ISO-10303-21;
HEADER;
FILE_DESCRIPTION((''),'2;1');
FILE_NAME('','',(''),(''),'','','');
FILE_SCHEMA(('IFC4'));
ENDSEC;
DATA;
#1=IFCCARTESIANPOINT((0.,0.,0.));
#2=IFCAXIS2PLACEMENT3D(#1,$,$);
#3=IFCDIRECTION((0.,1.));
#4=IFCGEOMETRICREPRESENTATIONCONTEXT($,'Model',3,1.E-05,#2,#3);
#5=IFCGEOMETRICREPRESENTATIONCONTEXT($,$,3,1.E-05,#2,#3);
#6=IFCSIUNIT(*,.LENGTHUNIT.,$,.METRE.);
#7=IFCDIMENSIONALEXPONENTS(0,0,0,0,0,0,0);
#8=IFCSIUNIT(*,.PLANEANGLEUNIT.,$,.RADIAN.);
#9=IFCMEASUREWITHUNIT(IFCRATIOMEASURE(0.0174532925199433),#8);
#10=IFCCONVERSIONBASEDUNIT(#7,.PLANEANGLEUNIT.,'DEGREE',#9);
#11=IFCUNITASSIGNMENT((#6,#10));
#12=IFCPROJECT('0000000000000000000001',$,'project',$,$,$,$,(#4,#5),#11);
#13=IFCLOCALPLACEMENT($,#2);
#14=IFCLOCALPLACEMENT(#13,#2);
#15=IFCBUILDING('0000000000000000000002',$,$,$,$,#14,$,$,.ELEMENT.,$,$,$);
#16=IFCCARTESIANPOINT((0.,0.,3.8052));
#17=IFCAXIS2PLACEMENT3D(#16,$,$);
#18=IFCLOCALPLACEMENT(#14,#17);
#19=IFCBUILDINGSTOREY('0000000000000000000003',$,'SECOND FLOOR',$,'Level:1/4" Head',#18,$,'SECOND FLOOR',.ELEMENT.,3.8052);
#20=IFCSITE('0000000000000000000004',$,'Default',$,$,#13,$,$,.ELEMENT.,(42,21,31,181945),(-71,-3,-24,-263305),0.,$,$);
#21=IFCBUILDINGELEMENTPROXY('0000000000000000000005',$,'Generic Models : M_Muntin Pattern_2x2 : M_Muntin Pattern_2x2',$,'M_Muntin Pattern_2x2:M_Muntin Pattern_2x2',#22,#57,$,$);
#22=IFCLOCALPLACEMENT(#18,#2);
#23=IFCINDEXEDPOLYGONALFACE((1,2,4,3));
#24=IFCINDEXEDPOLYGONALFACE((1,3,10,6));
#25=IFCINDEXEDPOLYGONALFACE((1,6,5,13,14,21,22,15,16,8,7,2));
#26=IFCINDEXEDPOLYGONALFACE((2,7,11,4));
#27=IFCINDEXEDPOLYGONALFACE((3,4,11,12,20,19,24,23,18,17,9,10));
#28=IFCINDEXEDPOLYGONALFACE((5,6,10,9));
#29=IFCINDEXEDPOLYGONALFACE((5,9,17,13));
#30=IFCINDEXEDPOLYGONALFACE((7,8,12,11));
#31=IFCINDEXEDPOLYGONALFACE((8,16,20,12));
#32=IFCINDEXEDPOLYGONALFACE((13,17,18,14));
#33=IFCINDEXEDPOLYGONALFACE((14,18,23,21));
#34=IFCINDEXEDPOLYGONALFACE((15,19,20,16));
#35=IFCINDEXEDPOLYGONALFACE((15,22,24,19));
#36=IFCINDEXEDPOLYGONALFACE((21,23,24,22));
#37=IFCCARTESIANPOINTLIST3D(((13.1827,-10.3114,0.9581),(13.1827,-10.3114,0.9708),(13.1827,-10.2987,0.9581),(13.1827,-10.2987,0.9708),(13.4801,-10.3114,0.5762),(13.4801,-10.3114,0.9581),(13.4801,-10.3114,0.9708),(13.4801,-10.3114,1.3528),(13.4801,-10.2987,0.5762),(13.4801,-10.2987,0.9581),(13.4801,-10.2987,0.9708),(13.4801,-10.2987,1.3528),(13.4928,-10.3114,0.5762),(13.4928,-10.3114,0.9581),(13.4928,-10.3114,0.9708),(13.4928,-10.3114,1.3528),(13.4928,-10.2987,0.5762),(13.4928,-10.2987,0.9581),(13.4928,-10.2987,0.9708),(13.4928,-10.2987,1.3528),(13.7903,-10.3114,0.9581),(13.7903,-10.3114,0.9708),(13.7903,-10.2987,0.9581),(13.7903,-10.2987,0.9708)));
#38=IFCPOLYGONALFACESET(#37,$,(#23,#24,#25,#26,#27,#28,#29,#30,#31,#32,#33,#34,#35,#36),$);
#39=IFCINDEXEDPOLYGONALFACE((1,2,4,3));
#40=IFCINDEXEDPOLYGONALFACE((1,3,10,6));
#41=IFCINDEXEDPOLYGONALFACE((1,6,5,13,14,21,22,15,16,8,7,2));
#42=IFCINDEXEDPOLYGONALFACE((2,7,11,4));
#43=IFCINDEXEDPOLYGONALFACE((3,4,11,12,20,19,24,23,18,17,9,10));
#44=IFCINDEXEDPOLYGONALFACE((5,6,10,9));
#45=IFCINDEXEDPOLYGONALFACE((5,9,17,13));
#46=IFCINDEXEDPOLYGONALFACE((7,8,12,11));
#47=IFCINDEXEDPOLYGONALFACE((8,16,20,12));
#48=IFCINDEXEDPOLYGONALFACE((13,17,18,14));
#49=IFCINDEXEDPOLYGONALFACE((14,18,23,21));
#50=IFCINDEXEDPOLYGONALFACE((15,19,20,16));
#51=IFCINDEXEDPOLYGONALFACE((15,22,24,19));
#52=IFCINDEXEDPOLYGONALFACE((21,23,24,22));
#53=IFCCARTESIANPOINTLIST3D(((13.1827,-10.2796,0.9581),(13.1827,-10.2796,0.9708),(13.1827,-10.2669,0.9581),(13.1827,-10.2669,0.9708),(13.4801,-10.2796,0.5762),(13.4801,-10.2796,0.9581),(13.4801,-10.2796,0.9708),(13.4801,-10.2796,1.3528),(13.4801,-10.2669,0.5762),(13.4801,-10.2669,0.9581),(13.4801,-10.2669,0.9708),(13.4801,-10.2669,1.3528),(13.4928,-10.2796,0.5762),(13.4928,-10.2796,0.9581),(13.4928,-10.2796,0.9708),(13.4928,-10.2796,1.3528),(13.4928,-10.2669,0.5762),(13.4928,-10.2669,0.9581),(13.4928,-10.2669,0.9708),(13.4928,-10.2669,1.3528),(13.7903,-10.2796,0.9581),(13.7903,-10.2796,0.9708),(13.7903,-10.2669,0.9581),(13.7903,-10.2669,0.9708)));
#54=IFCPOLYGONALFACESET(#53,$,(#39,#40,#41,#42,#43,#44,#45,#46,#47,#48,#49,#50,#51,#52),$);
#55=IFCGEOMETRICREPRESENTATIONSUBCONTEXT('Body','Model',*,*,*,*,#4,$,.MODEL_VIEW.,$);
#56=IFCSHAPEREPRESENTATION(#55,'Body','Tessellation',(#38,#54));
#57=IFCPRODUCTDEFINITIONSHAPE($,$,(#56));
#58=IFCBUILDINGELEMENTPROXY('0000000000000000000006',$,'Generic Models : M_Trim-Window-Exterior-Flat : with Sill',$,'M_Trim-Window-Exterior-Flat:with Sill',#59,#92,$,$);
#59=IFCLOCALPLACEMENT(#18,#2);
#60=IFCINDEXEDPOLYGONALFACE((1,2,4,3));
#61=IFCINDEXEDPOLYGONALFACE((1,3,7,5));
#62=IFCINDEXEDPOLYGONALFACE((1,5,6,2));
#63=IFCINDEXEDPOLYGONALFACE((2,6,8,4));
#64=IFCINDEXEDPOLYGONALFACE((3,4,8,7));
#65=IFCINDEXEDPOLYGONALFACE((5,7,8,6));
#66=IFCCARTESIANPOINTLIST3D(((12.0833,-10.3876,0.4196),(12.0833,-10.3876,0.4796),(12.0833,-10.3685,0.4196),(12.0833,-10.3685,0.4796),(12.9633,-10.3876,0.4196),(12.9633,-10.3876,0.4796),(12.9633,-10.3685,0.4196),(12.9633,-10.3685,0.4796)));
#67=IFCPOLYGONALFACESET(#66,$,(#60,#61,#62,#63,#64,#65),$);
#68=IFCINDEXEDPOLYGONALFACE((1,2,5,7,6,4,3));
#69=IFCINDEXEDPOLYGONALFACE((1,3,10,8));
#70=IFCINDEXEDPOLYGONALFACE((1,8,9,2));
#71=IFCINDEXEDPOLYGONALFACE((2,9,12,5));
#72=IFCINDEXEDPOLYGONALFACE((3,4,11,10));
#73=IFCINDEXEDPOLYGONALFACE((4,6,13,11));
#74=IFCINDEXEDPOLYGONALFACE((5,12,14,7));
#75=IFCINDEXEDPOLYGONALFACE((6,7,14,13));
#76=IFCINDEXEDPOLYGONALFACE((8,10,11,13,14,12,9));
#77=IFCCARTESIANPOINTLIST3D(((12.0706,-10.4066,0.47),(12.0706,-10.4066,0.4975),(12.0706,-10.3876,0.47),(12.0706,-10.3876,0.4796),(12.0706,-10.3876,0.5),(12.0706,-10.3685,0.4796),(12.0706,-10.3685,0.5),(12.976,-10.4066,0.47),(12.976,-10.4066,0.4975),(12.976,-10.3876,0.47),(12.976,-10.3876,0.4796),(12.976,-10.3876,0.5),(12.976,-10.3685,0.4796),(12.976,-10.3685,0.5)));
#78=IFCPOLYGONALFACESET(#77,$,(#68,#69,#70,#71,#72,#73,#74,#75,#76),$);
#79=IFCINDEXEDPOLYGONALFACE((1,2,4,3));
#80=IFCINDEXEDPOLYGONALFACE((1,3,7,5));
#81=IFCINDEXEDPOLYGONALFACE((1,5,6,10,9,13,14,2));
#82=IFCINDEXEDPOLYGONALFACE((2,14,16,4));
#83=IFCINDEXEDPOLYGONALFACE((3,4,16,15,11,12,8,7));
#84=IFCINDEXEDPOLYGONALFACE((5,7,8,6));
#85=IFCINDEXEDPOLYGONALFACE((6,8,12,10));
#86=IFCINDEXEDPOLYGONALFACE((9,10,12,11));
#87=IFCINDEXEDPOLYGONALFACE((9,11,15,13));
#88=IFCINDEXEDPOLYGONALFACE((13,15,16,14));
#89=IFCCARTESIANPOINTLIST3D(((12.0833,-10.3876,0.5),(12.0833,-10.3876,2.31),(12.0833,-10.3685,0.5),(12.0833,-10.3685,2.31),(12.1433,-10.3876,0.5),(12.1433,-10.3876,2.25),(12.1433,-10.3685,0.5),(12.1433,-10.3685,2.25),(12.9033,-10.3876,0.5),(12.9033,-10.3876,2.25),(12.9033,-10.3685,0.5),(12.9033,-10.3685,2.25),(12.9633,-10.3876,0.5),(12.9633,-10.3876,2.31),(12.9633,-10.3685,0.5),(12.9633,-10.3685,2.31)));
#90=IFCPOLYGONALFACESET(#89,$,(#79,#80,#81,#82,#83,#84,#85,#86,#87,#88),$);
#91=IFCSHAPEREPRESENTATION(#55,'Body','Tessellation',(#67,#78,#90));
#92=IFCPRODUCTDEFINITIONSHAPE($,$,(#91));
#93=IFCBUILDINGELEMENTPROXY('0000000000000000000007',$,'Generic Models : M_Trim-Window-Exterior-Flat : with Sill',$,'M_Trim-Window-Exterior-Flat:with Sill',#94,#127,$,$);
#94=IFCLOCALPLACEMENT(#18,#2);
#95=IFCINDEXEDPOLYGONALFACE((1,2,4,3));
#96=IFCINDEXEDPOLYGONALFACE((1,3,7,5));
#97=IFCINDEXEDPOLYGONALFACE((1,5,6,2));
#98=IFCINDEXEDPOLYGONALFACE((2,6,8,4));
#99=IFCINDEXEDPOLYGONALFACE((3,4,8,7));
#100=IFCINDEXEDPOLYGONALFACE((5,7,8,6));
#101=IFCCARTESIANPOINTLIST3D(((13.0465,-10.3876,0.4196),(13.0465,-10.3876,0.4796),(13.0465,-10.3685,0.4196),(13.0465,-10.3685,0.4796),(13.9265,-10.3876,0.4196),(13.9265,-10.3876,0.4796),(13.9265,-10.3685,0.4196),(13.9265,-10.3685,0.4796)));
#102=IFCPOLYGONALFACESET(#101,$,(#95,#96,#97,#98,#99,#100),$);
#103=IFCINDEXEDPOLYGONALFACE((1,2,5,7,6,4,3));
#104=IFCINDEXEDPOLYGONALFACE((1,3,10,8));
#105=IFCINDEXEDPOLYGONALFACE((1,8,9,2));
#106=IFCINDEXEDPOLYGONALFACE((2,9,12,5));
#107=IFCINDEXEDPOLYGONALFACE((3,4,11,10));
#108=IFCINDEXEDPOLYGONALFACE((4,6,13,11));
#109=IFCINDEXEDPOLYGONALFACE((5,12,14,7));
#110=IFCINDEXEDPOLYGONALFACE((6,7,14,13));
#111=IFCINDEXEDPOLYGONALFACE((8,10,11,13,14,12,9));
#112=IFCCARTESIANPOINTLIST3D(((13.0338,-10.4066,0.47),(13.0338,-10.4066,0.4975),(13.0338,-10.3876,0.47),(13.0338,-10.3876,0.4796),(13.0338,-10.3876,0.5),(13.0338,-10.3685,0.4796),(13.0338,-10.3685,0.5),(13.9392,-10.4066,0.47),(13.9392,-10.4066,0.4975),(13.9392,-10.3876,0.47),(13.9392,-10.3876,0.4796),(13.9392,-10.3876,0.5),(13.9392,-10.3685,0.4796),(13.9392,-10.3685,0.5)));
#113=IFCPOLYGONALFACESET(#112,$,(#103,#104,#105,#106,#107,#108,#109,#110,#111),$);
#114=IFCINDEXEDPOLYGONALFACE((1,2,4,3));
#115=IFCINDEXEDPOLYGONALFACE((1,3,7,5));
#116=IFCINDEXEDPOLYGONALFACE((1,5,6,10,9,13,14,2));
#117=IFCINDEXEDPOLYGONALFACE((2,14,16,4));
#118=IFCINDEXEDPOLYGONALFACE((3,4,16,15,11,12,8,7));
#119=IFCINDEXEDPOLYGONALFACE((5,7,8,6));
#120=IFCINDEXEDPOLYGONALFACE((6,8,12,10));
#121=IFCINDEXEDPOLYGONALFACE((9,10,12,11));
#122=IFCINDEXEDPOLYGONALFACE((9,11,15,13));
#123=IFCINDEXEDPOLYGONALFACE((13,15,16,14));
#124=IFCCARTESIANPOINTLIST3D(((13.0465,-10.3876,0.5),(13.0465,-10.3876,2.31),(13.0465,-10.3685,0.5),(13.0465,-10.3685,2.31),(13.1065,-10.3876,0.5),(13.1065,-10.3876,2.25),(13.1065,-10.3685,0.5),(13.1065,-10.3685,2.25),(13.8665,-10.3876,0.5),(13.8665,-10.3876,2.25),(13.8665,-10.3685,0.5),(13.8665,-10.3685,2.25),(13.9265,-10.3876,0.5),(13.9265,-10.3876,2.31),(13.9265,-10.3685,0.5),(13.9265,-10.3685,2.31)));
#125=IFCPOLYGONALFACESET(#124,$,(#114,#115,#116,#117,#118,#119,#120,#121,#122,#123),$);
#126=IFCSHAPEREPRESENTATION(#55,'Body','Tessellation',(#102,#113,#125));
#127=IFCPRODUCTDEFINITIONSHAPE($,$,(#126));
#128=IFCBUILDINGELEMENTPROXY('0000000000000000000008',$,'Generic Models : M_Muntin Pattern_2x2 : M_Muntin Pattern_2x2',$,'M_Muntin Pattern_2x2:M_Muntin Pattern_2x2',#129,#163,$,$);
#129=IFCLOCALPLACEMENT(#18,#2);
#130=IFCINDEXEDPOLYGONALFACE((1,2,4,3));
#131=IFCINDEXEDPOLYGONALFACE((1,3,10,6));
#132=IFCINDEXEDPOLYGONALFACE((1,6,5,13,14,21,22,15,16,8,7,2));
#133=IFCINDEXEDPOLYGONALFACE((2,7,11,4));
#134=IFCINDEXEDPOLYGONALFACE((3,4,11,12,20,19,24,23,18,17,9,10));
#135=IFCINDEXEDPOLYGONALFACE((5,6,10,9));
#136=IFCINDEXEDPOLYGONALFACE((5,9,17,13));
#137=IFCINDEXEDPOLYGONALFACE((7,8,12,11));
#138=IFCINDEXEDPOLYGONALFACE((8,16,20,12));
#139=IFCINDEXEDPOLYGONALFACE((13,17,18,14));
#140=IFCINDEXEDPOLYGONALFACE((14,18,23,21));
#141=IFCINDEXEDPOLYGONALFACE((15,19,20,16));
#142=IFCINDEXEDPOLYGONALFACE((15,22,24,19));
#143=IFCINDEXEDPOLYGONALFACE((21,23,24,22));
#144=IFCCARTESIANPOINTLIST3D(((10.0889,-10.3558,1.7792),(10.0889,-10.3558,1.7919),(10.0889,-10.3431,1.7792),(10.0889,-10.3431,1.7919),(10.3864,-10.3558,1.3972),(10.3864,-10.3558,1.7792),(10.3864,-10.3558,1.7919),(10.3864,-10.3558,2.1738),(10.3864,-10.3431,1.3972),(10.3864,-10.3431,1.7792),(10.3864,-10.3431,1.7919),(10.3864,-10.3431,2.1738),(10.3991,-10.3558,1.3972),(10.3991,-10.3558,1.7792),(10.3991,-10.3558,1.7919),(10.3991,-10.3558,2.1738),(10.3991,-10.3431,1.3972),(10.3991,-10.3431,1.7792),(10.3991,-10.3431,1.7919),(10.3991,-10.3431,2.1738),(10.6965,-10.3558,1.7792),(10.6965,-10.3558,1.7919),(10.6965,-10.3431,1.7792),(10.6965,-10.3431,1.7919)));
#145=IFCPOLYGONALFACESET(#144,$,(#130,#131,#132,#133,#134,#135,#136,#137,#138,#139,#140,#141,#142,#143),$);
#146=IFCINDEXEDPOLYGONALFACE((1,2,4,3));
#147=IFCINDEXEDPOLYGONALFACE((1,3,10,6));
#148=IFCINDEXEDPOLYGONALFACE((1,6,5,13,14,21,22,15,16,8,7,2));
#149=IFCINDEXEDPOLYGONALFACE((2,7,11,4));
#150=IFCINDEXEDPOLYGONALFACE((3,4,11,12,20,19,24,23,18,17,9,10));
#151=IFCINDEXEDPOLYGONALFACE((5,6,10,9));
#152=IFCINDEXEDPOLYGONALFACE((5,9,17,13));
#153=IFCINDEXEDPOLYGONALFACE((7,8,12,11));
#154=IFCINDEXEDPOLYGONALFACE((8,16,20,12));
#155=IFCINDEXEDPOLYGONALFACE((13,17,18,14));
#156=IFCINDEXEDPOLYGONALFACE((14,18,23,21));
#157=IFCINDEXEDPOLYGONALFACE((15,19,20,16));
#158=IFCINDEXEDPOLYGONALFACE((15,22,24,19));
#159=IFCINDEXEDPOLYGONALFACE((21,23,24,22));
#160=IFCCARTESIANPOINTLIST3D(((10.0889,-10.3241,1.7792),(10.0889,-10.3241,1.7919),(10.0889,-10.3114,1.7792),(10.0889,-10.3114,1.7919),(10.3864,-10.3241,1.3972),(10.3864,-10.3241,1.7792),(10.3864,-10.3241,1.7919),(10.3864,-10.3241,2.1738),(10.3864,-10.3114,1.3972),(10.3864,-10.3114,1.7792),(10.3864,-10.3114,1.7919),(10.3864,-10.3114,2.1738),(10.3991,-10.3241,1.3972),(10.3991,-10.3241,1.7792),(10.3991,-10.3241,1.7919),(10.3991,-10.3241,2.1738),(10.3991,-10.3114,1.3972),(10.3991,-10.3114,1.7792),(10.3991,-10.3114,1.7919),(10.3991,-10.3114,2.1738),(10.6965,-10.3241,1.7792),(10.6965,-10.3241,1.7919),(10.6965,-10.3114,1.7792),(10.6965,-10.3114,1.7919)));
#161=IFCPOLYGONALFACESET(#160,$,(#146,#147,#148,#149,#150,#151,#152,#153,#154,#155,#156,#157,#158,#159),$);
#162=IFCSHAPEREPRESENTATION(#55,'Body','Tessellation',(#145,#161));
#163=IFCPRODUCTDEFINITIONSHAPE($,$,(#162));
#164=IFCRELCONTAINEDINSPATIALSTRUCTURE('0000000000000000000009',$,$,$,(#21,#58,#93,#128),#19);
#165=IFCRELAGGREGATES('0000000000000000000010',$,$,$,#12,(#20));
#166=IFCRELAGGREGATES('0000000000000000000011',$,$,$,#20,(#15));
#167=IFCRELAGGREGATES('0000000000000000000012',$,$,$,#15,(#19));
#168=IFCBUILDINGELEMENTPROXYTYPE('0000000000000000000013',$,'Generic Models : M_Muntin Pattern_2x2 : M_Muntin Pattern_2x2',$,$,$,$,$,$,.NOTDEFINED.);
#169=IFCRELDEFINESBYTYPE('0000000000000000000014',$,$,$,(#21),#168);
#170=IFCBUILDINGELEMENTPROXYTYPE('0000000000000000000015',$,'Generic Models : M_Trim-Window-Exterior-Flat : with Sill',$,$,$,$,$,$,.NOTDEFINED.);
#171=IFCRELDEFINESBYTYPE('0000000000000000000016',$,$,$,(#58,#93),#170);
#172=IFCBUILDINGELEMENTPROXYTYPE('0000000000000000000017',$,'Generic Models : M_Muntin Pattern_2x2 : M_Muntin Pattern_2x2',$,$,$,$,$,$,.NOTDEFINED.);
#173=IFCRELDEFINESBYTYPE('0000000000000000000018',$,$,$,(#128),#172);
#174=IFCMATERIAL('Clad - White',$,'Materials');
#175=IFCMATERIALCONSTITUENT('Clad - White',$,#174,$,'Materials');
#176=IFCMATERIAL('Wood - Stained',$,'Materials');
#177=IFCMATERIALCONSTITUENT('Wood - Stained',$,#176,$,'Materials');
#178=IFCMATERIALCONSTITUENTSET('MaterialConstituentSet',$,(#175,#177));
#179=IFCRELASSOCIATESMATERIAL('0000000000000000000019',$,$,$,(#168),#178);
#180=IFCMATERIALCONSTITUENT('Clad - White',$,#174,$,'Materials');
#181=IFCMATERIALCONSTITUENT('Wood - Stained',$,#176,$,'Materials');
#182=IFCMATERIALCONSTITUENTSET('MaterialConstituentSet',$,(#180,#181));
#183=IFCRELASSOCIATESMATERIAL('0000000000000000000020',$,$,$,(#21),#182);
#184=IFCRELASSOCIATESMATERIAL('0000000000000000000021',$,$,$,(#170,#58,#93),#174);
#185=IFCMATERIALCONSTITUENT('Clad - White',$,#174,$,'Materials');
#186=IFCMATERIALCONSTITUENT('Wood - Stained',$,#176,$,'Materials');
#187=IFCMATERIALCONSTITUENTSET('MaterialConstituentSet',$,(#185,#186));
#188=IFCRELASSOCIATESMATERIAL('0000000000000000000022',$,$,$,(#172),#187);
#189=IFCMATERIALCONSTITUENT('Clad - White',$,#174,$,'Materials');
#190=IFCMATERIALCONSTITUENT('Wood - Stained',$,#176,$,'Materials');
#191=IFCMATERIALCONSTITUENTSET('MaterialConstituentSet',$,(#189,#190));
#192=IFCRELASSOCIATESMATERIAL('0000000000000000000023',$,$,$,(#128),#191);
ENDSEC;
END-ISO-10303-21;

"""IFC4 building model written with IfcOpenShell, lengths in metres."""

from ifc_helpers import new_model, entity, si_unit, converted_unit, direction, frame, origin, origin_2d_with_axis, place, context, subcontext, project, spatial, polyline, rectangle, outline, extrude, source, transform, mapped, material, constituent, constituent_set, type_object, type_shapes, element, save


model = new_model("IFC4")

# Units and contexts
model_context = context("Model", 3, precision=1e-05, world=origin(), true_north=direction((0.0, 1.0)))
context_of_model = context(None, 3, precision=1e-05, world=origin(), true_north=direction((0.0, 1.0)))
body_context = subcontext(model_context, "Body", "Model", "MODEL_VIEW")
ifc_project = project(units=[si_unit("LENGTHUNIT", "METRE"), converted_unit("PLANEANGLEUNIT", "DEGREE", entity("IfcRatioMeasure", 0.0174532925199433), si_unit("PLANEANGLEUNIT", "RADIAN"), dimensions=[0, 0, 0, 0, 0, 0, 0])], contexts=[model_context, context_of_model])

# Site, building, storey
site_placement = place(None, origin())
site = spatial("IfcSite", under=ifc_project, at=site_placement, Name="Default", CompositionType="ELEMENT", RefLatitude=(42, 21, 31, 181945), RefLongitude=(-71, -3, -24, -263305), RefElevation=0.0)
building_placement = place(site_placement, origin())
building = spatial("IfcBuilding", under=site, at=building_placement, CompositionType="ELEMENT")
storey_placement = place(building_placement, frame((0.0, 0.0, 3.8052)))
storey = spatial("IfcBuildingStorey", under=building, at=storey_placement, Name="SECOND FLOOR", ObjectType="Level:1/4\" Head", LongName="SECOND FLOOR", CompositionType="ELEMENT", Elevation=3.8052)

# Shared definitions
ifc_material_1 = material(Name="Wood - Stained", Category="Materials")

# Building element proxies
ifc_material_2 = material(Name="Clad - White", Category="Materials")
ifc_constituent_1 = constituent(ifc_material_2, Name="Clad - White", Category="Materials")
ifc_constituent_2 = constituent(ifc_material_1, Name="Wood - Stained", Category="Materials")
ifc_constituent_set_1 = constituent_set(constituents=[ifc_constituent_1, ifc_constituent_2], Name="MaterialConstituentSet")
building_element_proxy_type_1 = type_object("IfcBuildingElementProxyType", Name="Generic Models : M_Muntin Pattern_2x2 : M_Muntin Pattern_2x2", PredefinedType="NOTDEFINED", material=ifc_constituent_set_1)
shared_shape_1 = source(origin(), body_context, "Body", "SweptSolid", [
    extrude(outline(polyline([(0.0064, -0.0064), (0.3883, -0.0064), (0.3883, 0.0063), (0.0064, 0.0063), (0.0064, 0.3038), (-0.0063, 0.3038), (-0.0063, 0.0063), (-0.3883, 0.0063), (-0.3883, -0.0064), (-0.0063, -0.0064), (-0.0063, -0.3038), (0.0064, -0.3038), (0.0064, -0.0064)])), frame((0.0, 0.0095, 0.3883), z_axis=(0.0, 1.0, 0.0), x_axis=(0.0, 0.0, 1.0)), (0.0, 0.0, 1.0), 0.0127),
    extrude(outline(polyline([(0.0064, -0.0064), (0.3883, -0.0064), (0.3883, 0.0063), (0.0064, 0.0063), (0.0064, 0.3038), (-0.0063, 0.3038), (-0.0063, 0.0063), (-0.3883, 0.0063), (-0.3883, -0.0064), (-0.0063, -0.0064), (-0.0063, -0.3038), (0.0064, -0.3038), (0.0064, -0.0064)])), frame((0.0, -0.0222, 0.3883), z_axis=(0.0, 1.0, 0.0), x_axis=(0.0, 0.0, 1.0)), (0.0, 0.0, 1.0), 0.0127),
])
type_shapes(building_element_proxy_type_1, [shared_shape_1])
ifc_constituent_3 = constituent(ifc_material_2, Name="Clad - White", Category="Materials")
ifc_constituent_4 = constituent(ifc_material_1, Name="Wood - Stained", Category="Materials")
ifc_constituent_set_2 = constituent_set(constituents=[ifc_constituent_3, ifc_constituent_4], Name="MaterialConstituentSet")
proxy_1_placement = place(storey_placement, frame((13.4865, -10.2891, 0.5762), z_axis=(0.0, 0.0, 1.0), x_axis=(-1.0, 0.0, 0.0)))
element("IfcBuildingElementProxy", 1, at=proxy_1_placement, inside=storey, type_object=building_element_proxy_type_1, material=ifc_constituent_set_2, Name="Generic Models : M_Muntin Pattern_2x2 : M_Muntin Pattern_2x2", ObjectType="M_Muntin Pattern_2x2:M_Muntin Pattern_2x2", context=body_context, shape_type="MappedRepresentation", body=[
    mapped(shared_shape_1, transform((0.0, 0.0, 0.0), scale=1.0)),
])
building_element_proxy_type_2 = type_object("IfcBuildingElementProxyType", Name="Generic Models : M_Trim-Window-Exterior-Flat : with Sill", PredefinedType="NOTDEFINED", material=ifc_material_2)
shared_shape_2 = source(origin(), body_context, "Body", "SweptSolid", [
    extrude(rectangle(XDim=0.88, YDim=0.06, at=origin_2d_with_axis()), frame((0.0, -1.8004, 0.0), z_axis=(0.0, 0.0, 1.0), x_axis=(-1.0, 0.0, 0.0)), (0.0, 0.0, 1.0), 0.0191),
    extrude(outline(polyline([(-0.019, -0.0152), (0.0, -0.0152), (0.0, -0.0057), (0.019, -0.0057), (0.019, 0.0148), (0.0, 0.0148), (-0.019, 0.0123), (-0.019, -0.0152)])), frame((-0.4527, -1.7648, 0.019), z_axis=(1.0, 0.0, 0.0), x_axis=(0.0, 0.0, -1.0)), (0.0, 0.0, 1.0), 0.9054),
    extrude(outline(polyline([(-0.92, -0.44), (0.89, -0.44), (0.89, -0.38), (-0.86, -0.38), (-0.86, 0.38), (0.89, 0.38), (0.89, 0.44), (-0.92, 0.44), (-0.92, -0.44)])), frame((0.0, -0.86, 0.0), z_axis=(0.0, 0.0, 1.0), x_axis=(0.0, -1.0, 0.0)), (0.0, 0.0, 1.0), 0.0191),
])
type_shapes(building_element_proxy_type_2, [shared_shape_2])
for number, where, z_axis, x_axis, name in (
    (2, (12.5233, -10.3685, 2.25), (0.0, -1.0, 0.0), (1.0, 0.0, 0.0), "Generic Models : M_Trim-Window-Exterior-Flat : with Sill"),
    (3, (13.4865, -10.3685, 2.25), (0.0, -1.0, 0.0), (1.0, 0.0, 0.0), "Generic Models : M_Trim-Window-Exterior-Flat : with Sill"),
):
    element("IfcBuildingElementProxy", number, at=place(storey_placement, frame(where, z_axis=z_axis, x_axis=x_axis)), inside=storey, type_object=building_element_proxy_type_2, material=ifc_material_2, Name=name, ObjectType="M_Trim-Window-Exterior-Flat:with Sill", context=body_context, shape_type="MappedRepresentation", body=[
        mapped(shared_shape_2, transform((0.0, 0.0, 0.0), scale=1.0)),
    ])
ifc_constituent_5 = constituent(ifc_material_2, Name="Clad - White", Category="Materials")
ifc_constituent_6 = constituent(ifc_material_1, Name="Wood - Stained", Category="Materials")
ifc_constituent_set_3 = constituent_set(constituents=[ifc_constituent_5, ifc_constituent_6], Name="MaterialConstituentSet")
ifc_constituent_7 = constituent(ifc_material_2, Name="Clad - White", Category="Materials")
ifc_constituent_8 = constituent(ifc_material_1, Name="Wood - Stained", Category="Materials")
ifc_constituent_set_4 = constituent_set(constituents=[ifc_constituent_7, ifc_constituent_8], Name="MaterialConstituentSet")
building_element_proxy_type_3 = type_object("IfcBuildingElementProxyType", Name="Generic Models : M_Muntin Pattern_2x2 : M_Muntin Pattern_2x2", PredefinedType="NOTDEFINED", material=ifc_constituent_set_4)
shared_shape_3 = source(origin(), body_context, "Body", "SweptSolid", [
    extrude(outline(polyline([(0.0064, -0.0064), (0.3883, -0.0064), (0.3883, 0.0063), (0.0064, 0.0063), (0.0064, 0.3038), (-0.0063, 0.3038), (-0.0063, 0.0063), (-0.3883, 0.0063), (-0.3883, -0.0064), (-0.0063, -0.0064), (-0.0063, -0.3038), (0.0064, -0.3038), (0.0064, -0.0064)])), frame((0.0, -0.0222, 0.3883), z_axis=(0.0, 1.0, 0.0), x_axis=(0.0, 0.0, 1.0)), (0.0, 0.0, 1.0), 0.0127),
    extrude(outline(polyline([(0.0064, -0.0064), (0.3883, -0.0064), (0.3883, 0.0063), (0.0064, 0.0063), (0.0064, 0.3038), (-0.0063, 0.3038), (-0.0063, 0.0063), (-0.3883, 0.0063), (-0.3883, -0.0064), (-0.0063, -0.0064), (-0.0063, -0.3038), (0.0064, -0.3038), (0.0064, -0.0064)])), frame((0.0, 0.0095, 0.3883), z_axis=(0.0, 1.0, 0.0), x_axis=(0.0, 0.0, 1.0)), (0.0, 0.0, 1.0), 0.0127),
])
type_shapes(building_element_proxy_type_3, [shared_shape_3])
proxy_2_placement = place(storey_placement, frame((10.3927, -10.3336, 1.3972)))
element("IfcBuildingElementProxy", 4, at=proxy_2_placement, inside=storey, type_object=building_element_proxy_type_3, material=ifc_constituent_set_3, Name="Generic Models : M_Muntin Pattern_2x2 : M_Muntin Pattern_2x2", ObjectType="M_Muntin Pattern_2x2:M_Muntin Pattern_2x2", context=body_context, shape_type="MappedRepresentation", body=[
    mapped(shared_shape_3, transform((0.0, 0.0, 0.0), scale=1.0)),
])

save(model, "model.ifc")
